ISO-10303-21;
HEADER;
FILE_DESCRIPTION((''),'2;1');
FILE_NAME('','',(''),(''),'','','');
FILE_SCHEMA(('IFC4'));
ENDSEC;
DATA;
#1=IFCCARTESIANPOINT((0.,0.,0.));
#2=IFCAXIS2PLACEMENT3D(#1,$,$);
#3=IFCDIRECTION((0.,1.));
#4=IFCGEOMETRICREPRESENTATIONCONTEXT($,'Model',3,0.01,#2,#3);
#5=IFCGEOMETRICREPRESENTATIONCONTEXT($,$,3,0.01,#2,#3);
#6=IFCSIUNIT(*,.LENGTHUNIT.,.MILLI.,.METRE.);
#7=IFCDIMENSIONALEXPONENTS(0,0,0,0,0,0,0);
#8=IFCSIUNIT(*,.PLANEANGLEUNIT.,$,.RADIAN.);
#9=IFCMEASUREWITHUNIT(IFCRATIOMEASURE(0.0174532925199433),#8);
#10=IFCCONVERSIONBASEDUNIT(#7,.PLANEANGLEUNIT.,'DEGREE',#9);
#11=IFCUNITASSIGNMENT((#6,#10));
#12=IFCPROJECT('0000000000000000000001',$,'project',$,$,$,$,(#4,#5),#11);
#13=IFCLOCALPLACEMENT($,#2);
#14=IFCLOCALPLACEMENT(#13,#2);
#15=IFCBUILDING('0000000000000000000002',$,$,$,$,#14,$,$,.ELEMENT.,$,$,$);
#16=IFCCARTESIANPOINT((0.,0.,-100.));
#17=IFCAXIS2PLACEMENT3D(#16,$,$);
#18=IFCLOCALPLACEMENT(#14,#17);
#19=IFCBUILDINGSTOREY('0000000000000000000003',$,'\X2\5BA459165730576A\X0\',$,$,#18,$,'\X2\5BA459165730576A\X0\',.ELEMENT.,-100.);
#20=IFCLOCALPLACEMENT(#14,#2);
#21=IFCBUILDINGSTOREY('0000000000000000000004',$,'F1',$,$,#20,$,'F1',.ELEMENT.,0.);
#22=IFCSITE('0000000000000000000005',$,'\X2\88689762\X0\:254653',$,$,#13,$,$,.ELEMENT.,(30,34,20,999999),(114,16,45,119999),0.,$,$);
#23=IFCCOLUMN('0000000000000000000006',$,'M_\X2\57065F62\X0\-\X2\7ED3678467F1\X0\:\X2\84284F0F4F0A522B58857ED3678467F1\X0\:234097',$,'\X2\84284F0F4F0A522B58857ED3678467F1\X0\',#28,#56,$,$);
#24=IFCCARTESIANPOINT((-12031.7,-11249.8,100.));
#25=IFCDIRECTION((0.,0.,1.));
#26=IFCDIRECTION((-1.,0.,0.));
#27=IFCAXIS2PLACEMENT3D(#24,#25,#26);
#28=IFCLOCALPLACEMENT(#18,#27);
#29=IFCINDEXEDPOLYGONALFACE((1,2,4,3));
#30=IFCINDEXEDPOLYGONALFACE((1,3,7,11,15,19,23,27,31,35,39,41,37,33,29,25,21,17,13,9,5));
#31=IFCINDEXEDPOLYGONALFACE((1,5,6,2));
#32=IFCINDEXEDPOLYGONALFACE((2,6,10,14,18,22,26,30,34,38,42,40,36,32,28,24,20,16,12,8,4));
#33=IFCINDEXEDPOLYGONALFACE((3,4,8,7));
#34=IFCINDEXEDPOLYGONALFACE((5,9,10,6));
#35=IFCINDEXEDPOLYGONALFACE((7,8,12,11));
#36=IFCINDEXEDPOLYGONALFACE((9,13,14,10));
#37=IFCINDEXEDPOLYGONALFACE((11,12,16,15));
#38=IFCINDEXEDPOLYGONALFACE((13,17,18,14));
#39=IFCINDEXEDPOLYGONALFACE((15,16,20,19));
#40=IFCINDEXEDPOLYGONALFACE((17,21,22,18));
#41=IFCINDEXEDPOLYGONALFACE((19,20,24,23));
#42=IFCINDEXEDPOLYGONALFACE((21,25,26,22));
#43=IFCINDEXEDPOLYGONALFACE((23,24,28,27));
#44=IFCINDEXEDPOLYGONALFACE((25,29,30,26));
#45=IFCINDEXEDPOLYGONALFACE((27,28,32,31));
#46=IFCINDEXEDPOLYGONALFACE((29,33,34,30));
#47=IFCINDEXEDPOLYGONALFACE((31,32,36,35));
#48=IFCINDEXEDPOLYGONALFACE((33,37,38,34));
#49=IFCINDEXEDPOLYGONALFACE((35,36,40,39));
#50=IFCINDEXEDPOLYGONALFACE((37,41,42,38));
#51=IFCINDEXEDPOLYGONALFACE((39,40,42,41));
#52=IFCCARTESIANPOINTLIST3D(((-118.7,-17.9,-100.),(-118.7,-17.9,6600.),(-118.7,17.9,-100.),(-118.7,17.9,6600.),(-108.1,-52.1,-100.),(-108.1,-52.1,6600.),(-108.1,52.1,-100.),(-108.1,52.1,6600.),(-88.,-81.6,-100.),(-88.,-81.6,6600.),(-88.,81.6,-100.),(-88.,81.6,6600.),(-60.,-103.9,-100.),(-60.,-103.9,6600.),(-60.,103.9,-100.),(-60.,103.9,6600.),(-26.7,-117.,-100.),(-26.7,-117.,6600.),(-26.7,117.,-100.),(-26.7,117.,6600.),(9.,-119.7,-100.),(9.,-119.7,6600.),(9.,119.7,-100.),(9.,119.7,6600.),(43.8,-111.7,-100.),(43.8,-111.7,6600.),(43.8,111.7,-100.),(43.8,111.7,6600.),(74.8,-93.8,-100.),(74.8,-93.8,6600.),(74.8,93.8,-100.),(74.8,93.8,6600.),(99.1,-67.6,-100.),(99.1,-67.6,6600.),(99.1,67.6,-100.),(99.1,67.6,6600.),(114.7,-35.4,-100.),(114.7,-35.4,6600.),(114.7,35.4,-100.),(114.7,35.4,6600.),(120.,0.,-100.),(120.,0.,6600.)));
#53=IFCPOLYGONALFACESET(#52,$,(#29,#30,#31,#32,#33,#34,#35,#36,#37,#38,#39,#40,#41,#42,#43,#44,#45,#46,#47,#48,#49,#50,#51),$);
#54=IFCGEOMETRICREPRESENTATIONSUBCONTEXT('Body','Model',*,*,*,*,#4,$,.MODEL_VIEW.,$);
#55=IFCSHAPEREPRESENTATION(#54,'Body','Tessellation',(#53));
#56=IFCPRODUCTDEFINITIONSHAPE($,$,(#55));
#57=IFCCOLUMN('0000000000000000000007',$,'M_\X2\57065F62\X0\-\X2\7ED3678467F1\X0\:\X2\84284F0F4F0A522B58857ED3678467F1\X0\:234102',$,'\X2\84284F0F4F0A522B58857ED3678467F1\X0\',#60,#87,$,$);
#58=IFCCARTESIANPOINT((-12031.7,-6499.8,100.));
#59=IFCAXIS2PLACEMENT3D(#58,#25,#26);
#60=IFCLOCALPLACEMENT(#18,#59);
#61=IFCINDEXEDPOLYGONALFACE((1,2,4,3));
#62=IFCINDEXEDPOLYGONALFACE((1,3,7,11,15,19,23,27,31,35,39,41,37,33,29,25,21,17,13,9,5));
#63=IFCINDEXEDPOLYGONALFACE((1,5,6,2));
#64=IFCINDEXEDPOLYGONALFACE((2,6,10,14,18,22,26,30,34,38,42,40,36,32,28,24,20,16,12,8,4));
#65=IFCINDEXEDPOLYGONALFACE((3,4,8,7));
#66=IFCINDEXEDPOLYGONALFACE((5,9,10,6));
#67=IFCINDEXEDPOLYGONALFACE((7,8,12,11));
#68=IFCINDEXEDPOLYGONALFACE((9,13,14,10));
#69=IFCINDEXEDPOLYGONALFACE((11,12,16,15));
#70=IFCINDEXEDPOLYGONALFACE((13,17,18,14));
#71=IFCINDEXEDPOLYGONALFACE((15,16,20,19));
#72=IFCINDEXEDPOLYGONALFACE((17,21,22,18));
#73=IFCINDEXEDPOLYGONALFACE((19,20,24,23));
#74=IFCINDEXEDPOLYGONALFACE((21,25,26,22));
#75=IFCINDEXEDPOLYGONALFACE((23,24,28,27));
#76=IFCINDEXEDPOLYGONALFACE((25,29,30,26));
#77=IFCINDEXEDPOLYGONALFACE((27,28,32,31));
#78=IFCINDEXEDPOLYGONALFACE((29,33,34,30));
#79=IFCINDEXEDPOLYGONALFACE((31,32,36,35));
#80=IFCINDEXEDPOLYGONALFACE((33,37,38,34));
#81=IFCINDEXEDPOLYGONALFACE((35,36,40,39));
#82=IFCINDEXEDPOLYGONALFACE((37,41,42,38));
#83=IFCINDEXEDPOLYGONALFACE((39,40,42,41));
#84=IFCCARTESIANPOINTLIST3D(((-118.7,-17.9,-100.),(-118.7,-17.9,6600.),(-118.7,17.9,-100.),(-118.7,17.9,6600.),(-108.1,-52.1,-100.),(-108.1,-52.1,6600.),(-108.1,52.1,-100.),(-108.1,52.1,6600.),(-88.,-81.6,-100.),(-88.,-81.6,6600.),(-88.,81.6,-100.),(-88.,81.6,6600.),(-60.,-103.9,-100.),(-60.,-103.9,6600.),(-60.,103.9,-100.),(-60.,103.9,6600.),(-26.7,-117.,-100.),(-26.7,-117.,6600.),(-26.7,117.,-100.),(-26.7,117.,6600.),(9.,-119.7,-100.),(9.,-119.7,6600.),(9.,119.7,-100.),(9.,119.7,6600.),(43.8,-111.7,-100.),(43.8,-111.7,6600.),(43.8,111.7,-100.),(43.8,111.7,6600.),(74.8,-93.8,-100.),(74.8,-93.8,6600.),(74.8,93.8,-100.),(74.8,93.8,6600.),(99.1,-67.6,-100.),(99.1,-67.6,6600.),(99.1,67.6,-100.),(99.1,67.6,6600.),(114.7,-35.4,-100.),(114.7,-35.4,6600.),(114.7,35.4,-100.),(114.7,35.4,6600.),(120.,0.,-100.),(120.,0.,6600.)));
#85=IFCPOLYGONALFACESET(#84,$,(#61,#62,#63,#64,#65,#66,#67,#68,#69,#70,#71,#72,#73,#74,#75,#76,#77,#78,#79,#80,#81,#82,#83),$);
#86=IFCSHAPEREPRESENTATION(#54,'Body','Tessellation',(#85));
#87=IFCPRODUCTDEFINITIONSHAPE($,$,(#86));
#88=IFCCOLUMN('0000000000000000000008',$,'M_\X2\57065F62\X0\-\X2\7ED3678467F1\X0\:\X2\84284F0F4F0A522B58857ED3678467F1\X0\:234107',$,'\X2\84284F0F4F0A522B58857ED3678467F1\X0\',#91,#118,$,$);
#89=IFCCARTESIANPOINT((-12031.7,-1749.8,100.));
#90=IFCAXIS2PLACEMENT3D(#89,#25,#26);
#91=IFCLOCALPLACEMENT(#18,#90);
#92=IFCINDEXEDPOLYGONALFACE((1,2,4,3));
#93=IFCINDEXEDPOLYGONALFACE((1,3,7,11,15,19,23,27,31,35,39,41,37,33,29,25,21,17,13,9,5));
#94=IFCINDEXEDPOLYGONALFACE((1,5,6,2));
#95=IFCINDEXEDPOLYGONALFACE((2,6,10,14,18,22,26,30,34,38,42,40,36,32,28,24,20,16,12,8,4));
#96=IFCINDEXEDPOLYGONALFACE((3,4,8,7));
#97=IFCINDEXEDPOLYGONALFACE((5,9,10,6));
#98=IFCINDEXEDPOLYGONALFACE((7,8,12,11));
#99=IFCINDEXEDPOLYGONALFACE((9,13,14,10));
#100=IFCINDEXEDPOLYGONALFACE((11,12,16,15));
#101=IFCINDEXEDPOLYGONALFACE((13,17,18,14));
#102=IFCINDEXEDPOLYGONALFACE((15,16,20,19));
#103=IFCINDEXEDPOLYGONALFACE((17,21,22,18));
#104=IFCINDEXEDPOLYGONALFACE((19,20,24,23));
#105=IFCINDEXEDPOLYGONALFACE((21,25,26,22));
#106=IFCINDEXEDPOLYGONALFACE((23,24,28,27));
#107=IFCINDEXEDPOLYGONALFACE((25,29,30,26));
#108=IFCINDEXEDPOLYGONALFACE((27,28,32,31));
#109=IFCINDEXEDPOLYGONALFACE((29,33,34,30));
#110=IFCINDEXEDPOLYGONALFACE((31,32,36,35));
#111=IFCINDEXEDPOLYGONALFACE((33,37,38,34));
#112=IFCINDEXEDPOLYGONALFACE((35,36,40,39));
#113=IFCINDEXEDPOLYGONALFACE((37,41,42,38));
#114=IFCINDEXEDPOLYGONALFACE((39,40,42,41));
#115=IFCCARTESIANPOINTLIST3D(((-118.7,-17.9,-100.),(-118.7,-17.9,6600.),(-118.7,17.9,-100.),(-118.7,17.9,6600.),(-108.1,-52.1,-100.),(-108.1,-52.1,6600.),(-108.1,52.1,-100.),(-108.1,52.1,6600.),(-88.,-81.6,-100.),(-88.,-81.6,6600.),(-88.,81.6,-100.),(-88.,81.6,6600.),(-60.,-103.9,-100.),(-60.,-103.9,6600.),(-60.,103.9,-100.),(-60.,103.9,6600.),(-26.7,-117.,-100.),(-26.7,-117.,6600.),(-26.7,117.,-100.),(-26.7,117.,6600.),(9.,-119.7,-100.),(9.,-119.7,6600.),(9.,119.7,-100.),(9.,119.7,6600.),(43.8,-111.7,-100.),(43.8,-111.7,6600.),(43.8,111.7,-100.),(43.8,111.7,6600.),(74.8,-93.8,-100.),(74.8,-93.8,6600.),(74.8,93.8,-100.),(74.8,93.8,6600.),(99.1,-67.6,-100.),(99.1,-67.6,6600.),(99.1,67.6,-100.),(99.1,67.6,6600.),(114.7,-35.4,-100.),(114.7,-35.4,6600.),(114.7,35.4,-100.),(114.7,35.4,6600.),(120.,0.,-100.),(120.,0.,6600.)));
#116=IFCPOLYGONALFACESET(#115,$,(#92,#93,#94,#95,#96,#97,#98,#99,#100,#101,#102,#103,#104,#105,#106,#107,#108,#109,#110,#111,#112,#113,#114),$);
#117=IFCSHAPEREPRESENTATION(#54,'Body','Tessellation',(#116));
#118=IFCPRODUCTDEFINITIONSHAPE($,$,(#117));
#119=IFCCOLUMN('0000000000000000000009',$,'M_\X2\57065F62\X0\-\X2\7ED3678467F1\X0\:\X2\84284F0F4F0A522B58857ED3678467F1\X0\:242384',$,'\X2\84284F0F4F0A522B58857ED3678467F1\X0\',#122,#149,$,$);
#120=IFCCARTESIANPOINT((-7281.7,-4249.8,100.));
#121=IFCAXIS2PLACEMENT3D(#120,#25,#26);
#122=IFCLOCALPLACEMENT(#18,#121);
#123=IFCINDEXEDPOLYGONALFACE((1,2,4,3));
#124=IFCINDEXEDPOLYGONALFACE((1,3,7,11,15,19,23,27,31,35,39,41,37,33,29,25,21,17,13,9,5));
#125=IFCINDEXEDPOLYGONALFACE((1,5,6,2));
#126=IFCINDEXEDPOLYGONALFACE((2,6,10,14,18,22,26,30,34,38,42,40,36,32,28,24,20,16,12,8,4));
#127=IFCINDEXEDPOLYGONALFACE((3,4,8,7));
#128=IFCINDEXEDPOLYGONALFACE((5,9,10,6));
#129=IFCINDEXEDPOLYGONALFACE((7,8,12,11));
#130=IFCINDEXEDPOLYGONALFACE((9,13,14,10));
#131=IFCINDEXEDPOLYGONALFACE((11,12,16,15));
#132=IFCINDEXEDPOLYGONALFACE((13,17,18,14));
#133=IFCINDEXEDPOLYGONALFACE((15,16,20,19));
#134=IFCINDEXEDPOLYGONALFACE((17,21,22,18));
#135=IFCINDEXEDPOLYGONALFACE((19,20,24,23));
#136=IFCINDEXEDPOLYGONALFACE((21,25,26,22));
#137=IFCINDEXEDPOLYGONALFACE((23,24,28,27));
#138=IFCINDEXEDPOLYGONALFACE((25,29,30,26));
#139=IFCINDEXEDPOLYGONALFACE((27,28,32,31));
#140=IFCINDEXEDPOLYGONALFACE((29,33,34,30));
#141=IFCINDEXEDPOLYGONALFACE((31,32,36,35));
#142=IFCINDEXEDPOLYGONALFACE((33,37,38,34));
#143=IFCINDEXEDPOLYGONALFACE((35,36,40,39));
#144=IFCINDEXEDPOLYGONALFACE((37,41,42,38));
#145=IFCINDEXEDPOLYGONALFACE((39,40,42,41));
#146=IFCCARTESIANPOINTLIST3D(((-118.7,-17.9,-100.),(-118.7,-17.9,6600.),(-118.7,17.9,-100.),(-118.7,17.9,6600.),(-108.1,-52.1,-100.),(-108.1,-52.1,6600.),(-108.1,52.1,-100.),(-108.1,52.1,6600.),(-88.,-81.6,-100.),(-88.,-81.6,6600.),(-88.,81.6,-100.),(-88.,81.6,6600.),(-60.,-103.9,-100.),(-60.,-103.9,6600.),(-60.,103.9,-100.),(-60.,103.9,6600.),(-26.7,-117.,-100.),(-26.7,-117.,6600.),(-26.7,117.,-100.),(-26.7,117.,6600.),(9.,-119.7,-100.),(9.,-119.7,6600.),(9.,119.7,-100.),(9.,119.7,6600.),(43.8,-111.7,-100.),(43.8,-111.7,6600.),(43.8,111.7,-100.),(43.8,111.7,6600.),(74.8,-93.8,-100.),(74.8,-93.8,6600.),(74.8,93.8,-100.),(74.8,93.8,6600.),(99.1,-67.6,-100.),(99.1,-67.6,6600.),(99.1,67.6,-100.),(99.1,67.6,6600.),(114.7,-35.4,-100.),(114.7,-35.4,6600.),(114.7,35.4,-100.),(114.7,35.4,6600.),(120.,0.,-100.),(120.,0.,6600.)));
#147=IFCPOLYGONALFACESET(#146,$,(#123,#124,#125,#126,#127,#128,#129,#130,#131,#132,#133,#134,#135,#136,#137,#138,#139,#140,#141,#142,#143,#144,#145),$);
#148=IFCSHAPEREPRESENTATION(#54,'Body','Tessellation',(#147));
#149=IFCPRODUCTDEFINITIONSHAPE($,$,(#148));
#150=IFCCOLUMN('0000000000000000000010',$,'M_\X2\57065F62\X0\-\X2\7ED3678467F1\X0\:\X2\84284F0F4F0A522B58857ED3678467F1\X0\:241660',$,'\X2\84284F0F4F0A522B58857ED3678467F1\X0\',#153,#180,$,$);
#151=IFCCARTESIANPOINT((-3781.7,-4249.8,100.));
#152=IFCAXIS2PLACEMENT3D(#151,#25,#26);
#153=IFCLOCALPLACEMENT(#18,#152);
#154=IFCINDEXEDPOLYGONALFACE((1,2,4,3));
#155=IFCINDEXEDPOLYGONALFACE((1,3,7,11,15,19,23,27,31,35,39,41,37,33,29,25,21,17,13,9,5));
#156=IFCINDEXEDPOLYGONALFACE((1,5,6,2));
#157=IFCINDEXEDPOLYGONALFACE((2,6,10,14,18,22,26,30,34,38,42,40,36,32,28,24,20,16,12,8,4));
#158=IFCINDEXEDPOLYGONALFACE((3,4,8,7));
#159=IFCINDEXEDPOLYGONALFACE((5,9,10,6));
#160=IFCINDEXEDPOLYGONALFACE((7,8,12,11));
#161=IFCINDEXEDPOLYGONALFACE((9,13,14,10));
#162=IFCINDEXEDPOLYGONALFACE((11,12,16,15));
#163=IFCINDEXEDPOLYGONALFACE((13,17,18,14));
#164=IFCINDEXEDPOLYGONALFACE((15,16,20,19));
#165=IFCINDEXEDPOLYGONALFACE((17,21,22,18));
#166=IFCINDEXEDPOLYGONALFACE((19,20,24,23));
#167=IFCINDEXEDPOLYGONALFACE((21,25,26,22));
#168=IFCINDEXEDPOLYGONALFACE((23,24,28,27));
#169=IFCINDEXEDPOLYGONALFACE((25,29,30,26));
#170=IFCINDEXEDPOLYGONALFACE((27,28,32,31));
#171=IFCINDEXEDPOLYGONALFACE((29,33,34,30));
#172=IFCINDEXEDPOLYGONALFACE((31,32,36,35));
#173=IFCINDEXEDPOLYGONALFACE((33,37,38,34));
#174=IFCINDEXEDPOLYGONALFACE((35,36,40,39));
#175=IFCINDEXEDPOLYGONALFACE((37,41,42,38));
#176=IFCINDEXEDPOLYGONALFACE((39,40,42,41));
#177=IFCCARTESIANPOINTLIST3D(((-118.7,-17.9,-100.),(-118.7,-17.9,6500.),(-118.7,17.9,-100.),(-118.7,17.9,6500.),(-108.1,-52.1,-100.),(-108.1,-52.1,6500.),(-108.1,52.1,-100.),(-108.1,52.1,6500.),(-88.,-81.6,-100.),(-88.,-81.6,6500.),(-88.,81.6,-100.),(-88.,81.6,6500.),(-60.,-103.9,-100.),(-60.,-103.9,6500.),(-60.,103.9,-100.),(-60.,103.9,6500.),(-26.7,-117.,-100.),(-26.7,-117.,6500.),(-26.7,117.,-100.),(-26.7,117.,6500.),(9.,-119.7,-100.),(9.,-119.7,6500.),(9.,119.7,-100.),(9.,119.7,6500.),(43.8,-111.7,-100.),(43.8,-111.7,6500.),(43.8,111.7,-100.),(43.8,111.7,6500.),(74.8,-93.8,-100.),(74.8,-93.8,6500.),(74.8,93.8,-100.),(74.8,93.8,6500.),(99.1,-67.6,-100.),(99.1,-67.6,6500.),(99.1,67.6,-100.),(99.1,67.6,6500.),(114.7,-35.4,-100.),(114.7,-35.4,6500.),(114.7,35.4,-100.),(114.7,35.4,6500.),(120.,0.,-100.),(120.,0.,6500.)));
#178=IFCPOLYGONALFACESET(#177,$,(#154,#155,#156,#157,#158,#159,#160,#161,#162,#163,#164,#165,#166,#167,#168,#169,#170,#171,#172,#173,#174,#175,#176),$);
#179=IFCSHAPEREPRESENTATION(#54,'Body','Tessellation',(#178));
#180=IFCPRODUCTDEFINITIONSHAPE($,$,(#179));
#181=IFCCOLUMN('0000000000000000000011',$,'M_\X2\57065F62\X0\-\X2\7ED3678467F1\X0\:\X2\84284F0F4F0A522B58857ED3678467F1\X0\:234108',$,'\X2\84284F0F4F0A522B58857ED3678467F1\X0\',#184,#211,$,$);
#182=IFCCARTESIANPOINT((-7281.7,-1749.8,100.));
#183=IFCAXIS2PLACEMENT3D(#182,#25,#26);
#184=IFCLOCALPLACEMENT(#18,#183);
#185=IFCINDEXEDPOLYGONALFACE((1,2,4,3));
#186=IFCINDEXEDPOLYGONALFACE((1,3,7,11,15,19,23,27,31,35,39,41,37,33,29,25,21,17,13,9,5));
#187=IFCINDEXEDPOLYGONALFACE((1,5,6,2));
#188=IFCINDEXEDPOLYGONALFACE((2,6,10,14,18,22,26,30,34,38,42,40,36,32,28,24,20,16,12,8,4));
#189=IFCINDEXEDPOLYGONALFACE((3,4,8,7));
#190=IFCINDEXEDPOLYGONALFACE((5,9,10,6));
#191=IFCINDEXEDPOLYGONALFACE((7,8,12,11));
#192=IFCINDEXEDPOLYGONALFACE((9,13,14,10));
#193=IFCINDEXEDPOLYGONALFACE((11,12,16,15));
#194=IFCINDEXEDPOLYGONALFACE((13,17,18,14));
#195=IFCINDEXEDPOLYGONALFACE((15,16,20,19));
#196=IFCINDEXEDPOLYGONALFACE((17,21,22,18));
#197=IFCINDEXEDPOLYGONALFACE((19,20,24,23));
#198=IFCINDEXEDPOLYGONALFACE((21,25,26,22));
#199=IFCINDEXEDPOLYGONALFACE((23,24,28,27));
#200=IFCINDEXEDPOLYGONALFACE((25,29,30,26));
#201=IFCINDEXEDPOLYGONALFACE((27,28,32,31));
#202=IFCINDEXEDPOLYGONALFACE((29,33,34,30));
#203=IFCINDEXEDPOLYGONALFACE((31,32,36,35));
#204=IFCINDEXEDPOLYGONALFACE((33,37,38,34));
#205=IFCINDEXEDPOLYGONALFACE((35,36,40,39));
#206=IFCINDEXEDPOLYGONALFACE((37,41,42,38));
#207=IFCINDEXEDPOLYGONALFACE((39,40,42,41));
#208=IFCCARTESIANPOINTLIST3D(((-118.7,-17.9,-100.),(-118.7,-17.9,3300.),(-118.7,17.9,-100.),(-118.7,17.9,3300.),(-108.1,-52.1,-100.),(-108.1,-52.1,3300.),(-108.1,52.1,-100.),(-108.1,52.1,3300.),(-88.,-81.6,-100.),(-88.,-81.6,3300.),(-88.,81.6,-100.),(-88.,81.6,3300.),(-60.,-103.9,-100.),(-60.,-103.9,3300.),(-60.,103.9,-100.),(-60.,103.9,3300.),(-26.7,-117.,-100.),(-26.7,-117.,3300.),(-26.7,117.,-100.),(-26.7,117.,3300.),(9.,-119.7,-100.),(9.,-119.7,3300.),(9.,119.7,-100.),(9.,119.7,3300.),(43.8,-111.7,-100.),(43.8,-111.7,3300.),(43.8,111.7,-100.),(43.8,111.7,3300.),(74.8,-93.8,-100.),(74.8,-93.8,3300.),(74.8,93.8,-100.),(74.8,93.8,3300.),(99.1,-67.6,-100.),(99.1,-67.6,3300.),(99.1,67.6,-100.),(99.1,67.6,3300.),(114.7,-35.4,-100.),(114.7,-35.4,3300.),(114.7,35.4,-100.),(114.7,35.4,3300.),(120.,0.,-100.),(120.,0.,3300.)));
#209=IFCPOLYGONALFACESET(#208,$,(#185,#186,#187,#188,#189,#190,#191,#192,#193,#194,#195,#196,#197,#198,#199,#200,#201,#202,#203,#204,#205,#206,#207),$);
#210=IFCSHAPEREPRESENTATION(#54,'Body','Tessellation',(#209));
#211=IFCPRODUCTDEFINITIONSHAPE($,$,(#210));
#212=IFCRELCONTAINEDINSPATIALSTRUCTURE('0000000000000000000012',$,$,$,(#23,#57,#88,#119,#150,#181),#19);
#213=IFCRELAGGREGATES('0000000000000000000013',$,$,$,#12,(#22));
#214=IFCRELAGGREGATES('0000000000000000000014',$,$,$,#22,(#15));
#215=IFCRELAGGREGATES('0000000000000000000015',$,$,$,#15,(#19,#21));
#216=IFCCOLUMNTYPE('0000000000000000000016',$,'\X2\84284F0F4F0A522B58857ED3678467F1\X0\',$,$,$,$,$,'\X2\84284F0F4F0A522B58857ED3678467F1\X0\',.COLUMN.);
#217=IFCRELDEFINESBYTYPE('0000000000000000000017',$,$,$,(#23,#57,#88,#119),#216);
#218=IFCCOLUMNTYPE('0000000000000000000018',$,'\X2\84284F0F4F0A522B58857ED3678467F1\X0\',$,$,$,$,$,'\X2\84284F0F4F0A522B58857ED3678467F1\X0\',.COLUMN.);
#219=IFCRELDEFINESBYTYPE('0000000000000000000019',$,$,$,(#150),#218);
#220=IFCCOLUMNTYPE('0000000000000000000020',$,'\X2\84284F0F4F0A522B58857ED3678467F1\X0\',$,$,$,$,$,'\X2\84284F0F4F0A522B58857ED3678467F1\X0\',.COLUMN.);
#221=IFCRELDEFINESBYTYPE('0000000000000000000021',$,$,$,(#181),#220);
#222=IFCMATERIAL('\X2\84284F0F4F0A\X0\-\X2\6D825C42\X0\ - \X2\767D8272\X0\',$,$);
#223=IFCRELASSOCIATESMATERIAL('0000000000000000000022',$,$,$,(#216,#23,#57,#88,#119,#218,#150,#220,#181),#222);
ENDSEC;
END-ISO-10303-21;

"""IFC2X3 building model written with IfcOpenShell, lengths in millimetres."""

from ifc_helpers import new_model, entity, si_unit, converted_unit, direction, frame, frame_2d, origin, place, context, subcontext, project, spatial, circle, extrude, source, transform, mapped, material, type_object, type_shapes, element, save


model = new_model("IFC2X3")

# Units and contexts
model_context = context("Model", 3, precision=0.01, world=origin(), true_north=direction((0.0, 1.0)))
context_of_model = context(None, 3, precision=0.01, world=origin(), true_north=direction((0.0, 1.0)))
body_context = subcontext(model_context, "Body", "Model", "MODEL_VIEW")
ifc_project = project(units=[si_unit("LENGTHUNIT", "METRE", prefix="MILLI"), converted_unit("PLANEANGLEUNIT", "DEGREE", entity("IfcRatioMeasure", 0.0174532925199433), si_unit("PLANEANGLEUNIT", "RADIAN"), dimensions=[0, 0, 0, 0, 0, 0, 0])], contexts=[model_context, context_of_model])

# Site, building, storey
site_placement = place(None, origin())
site = spatial("IfcSite", under=ifc_project, at=site_placement, Name="表面:254653", CompositionType="ELEMENT", RefLatitude=(30, 34, 20, 999999), RefLongitude=(114, 16, 45, 119999), RefElevation=0.0)
building_placement = place(site_placement, origin())
building = spatial("IfcBuilding", under=site, at=building_placement, CompositionType="ELEMENT")
storey_1_placement = place(building_placement, frame((0.0, 0.0, -100.0)))
storey_1 = spatial("IfcBuildingStorey", under=building, at=storey_1_placement, Name="室外地坪", LongName="室外地坪", CompositionType="ELEMENT", Elevation=-100.0)

# Columns
ifc_material_1 = material(Name="萨伏伊-涂层 - 白色")
column_type_1 = type_object("IfcColumnType", Name="萨伏伊别墅结构柱", ElementType="萨伏伊别墅结构柱", PredefinedType="COLUMN", material=ifc_material_1)
shared_shape_1 = source(origin(), body_context, "Body", "SweptSolid", [
    extrude(circle(Radius=120.0, at=frame_2d((0.0, 0.0), x_axis=(1.0, 0.0))), frame((0.0, 0.0, -100.0)), (0.0, 0.0, 1.0), 6700.0),
])
type_shapes(column_type_1, [shared_shape_1])
for number, where, z_axis, x_axis, name in (
    (1, (-12031.7, -11249.8, 100.0), (0.0, 0.0, 1.0), (-1.0, 0.0, 0.0), "M_圆形-结构柱:萨伏伊别墅结构柱:234097"),
    (2, (-12031.7, -6499.8, 100.0), (0.0, 0.0, 1.0), (-1.0, 0.0, 0.0), "M_圆形-结构柱:萨伏伊别墅结构柱:234102"),
    (3, (-12031.7, -1749.8, 100.0), (0.0, 0.0, 1.0), (-1.0, 0.0, 0.0), "M_圆形-结构柱:萨伏伊别墅结构柱:234107"),
    (4, (-7281.7, -4249.8, 100.0), (0.0, 0.0, 1.0), (-1.0, 0.0, 0.0), "M_圆形-结构柱:萨伏伊别墅结构柱:242384"),
):
    element("IfcColumn", number, at=place(storey_1_placement, frame(where, z_axis=z_axis, x_axis=x_axis)), inside=storey_1, type_object=column_type_1, material=ifc_material_1, Name=name, ObjectType="萨伏伊别墅结构柱", context=body_context, shape_type="MappedRepresentation", body=[
        mapped(shared_shape_1, transform((0.0, 0.0, 0.0), scale=1.0)),
    ])
column_type_2 = type_object("IfcColumnType", Name="萨伏伊别墅结构柱", ElementType="萨伏伊别墅结构柱", PredefinedType="COLUMN", material=ifc_material_1)
shared_shape_2 = source(origin(), body_context, "Body", "SweptSolid", [
    extrude(circle(Radius=120.0, at=frame_2d((0.0, 0.0), x_axis=(1.0, 0.0))), frame((0.0, 0.0, -100.0)), (0.0, 0.0, 1.0), 6600.0),
])
type_shapes(column_type_2, [shared_shape_2])
column_1_placement = place(storey_1_placement, frame((-3781.7, -4249.8, 100.0), z_axis=(0.0, 0.0, 1.0), x_axis=(-1.0, 0.0, 0.0)))
element("IfcColumn", 5, at=column_1_placement, inside=storey_1, type_object=column_type_2, material=ifc_material_1, Name="M_圆形-结构柱:萨伏伊别墅结构柱:241660", ObjectType="萨伏伊别墅结构柱", context=body_context, shape_type="MappedRepresentation", body=[
    mapped(shared_shape_2, transform((0.0, 0.0, 0.0), scale=1.0)),
])
column_type_3 = type_object("IfcColumnType", Name="萨伏伊别墅结构柱", ElementType="萨伏伊别墅结构柱", PredefinedType="COLUMN", material=ifc_material_1)
shared_shape_3 = source(origin(), body_context, "Body", "SweptSolid", [
    extrude(circle(Radius=120.0, at=frame_2d((0.0, 0.0), x_axis=(1.0, 0.0))), frame((0.0, 0.0, -100.0)), (0.0, 0.0, 1.0), 3400.0),
])
type_shapes(column_type_3, [shared_shape_3])
column_2_placement = place(storey_1_placement, frame((-7281.7, -1749.8, 100.0), z_axis=(0.0, 0.0, 1.0), x_axis=(-1.0, 0.0, 0.0)))
element("IfcColumn", 6, at=column_2_placement, inside=storey_1, type_object=column_type_3, material=ifc_material_1, Name="M_圆形-结构柱:萨伏伊别墅结构柱:234108", ObjectType="萨伏伊别墅结构柱", context=body_context, shape_type="MappedRepresentation", body=[
    mapped(shared_shape_3, transform((0.0, 0.0, 0.0), scale=1.0)),
])

# Shared definitions
storey_2_placement = place(building_placement, origin())
storey_2 = spatial("IfcBuildingStorey", under=building, at=storey_2_placement, Name="F1", LongName="F1", CompositionType="ELEMENT", Elevation=0.0)

save(model, "model.ifc")
